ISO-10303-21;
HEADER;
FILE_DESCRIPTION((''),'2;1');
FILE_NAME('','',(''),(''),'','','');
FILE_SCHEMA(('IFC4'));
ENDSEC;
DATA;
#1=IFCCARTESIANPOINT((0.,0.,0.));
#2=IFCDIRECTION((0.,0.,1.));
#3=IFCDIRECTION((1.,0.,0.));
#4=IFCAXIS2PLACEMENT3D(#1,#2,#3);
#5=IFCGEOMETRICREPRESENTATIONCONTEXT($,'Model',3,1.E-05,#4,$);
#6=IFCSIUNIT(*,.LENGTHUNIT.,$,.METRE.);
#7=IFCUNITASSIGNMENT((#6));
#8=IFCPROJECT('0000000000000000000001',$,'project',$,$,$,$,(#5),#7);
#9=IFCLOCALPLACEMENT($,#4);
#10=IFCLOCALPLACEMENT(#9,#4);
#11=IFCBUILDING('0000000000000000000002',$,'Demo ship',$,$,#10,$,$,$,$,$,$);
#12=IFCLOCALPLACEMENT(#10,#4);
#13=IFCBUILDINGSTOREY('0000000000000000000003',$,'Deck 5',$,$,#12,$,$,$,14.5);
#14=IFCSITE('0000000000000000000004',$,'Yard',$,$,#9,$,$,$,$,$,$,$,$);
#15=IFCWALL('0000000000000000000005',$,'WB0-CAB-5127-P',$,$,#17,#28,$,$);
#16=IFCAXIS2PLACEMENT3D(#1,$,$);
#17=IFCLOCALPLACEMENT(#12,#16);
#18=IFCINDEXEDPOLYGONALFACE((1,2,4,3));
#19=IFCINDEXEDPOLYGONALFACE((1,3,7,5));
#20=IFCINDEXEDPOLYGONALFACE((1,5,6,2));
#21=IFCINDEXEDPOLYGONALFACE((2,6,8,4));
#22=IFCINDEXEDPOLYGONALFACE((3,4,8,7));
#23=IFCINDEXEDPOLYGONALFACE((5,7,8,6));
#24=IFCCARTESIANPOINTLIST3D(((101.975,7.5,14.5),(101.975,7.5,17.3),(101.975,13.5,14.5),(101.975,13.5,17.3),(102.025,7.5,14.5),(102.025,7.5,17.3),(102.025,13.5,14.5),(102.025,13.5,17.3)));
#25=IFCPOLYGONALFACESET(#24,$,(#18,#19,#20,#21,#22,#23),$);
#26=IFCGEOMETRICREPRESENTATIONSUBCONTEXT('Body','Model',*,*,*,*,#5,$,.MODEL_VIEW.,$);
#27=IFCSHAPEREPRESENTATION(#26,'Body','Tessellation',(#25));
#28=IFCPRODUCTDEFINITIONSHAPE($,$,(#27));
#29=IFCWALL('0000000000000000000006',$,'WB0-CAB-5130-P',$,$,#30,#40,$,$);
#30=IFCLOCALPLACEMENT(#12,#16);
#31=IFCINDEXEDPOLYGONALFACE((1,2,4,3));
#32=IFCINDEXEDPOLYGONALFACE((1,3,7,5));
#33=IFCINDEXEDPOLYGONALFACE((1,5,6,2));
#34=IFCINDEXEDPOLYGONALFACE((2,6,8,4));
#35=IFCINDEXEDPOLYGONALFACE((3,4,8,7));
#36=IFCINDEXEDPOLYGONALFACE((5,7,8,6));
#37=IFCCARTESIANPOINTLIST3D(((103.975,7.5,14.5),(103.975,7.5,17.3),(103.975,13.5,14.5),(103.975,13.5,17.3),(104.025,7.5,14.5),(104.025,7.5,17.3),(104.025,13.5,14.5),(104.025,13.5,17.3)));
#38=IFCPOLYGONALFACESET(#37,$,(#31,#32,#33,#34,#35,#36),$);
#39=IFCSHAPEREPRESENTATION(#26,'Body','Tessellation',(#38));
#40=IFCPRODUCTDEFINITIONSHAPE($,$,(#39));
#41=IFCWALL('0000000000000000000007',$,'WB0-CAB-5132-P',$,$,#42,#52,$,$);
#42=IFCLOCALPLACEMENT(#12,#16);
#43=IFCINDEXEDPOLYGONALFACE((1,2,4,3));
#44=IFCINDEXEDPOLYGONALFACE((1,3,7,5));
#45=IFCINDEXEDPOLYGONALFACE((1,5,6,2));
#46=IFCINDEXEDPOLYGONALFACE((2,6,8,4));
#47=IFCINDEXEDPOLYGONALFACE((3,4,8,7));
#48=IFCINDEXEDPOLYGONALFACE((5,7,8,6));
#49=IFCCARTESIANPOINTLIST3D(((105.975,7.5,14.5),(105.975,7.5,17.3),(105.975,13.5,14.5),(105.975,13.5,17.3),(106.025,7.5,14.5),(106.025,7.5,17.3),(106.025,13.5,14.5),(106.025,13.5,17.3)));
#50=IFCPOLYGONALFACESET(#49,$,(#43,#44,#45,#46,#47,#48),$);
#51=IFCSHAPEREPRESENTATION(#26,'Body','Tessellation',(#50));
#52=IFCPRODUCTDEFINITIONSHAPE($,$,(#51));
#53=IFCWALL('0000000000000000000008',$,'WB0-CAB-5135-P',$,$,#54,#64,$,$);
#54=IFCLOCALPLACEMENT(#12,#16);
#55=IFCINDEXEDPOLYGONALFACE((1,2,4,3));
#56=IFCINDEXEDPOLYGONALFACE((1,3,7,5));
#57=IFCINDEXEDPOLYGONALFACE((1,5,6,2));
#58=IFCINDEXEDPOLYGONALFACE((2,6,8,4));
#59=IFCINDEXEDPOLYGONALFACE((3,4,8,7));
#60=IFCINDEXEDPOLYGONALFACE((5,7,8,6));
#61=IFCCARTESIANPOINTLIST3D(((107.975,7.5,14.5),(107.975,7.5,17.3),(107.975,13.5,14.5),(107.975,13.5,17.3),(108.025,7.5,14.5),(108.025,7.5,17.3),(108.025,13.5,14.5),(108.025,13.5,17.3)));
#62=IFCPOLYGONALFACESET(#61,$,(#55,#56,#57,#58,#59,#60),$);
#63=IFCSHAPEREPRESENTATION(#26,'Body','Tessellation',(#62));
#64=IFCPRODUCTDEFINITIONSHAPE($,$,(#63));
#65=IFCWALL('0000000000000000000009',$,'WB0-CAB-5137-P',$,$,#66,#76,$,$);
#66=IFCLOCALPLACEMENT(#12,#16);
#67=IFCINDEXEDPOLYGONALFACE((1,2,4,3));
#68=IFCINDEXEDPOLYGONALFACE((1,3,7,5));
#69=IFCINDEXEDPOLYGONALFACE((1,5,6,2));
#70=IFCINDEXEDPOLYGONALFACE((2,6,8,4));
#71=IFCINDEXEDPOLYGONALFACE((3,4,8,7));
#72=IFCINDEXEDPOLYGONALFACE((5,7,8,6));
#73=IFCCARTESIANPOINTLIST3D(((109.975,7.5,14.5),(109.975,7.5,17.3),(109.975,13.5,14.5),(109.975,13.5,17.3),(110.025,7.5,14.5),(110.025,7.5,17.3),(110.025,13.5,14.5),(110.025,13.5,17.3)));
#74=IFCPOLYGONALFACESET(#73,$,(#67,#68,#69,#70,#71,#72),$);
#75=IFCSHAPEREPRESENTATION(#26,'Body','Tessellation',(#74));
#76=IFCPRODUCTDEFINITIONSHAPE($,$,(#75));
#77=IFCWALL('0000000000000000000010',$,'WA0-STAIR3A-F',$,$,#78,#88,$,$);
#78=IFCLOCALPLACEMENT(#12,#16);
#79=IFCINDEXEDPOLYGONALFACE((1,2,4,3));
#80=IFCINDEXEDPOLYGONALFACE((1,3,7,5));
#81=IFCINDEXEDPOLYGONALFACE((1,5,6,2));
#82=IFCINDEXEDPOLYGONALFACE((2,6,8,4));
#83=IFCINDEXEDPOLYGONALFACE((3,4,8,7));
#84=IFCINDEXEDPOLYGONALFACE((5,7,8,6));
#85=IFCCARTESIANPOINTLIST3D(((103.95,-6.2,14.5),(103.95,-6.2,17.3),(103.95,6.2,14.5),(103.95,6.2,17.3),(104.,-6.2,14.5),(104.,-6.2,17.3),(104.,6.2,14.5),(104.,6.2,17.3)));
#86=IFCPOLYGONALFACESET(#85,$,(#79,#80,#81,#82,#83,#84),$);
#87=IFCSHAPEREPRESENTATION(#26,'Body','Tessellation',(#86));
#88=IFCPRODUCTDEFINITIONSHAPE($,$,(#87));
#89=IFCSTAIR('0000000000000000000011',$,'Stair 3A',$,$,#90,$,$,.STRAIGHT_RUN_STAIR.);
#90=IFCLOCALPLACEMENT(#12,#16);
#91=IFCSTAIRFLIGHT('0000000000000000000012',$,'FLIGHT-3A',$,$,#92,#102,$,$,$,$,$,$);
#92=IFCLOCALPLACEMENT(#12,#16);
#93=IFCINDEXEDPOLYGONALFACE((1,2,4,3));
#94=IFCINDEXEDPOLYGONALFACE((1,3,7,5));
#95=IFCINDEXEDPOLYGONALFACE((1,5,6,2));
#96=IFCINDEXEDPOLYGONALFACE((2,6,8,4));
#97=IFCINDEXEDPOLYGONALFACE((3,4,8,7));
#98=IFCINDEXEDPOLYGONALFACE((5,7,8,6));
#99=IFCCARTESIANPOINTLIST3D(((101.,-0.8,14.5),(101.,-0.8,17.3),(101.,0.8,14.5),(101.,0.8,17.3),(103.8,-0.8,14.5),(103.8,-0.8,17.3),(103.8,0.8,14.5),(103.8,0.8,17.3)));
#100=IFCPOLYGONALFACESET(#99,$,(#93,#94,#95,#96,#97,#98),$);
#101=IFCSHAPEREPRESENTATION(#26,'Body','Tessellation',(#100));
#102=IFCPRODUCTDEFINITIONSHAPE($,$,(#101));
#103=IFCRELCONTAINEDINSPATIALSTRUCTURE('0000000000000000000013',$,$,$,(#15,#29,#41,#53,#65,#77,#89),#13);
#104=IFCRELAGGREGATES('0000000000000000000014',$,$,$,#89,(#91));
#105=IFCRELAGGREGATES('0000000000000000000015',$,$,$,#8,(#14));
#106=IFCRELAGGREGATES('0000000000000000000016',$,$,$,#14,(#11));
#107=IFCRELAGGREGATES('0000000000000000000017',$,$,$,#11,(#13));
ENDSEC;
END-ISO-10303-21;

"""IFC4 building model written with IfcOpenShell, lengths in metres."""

from ifc_helpers import new_model, si_unit, frame, frame_2d, origin, origin_with_axes, place, context, subcontext, project, spatial, rectangle, extrude, element, aggregate, save


model = new_model("IFC4")

# Units and contexts
model_context = context("Model", 3, precision=1e-05, world=origin_with_axes())
body_context = subcontext(model_context, "Body", "Model", "MODEL_VIEW")
ifc_project = project(units=[si_unit("LENGTHUNIT", "METRE")], contexts=[model_context])

# Site, building, storey
site_placement = place(None, origin_with_axes())
site = spatial("IfcSite", under=ifc_project, at=site_placement, Name="Yard")
building_placement = place(site_placement, origin_with_axes())
building = spatial("IfcBuilding", under=site, at=building_placement, Name="Demo ship")
storey_placement = place(building_placement, origin_with_axes())
storey = spatial("IfcBuildingStorey", under=building, at=storey_placement, Name="Deck 5", Elevation=14.5)

# Walls
for number, where, z_axis, x_axis, name in (
    (1, (101.975, 7.5, 14.5), (0.0, 0.0, 1.0), (1.0, 0.0, 0.0), "WB0-CAB-5127-P"),
    (2, (103.975, 7.5, 14.5), (0.0, 0.0, 1.0), (1.0, 0.0, 0.0), "WB0-CAB-5130-P"),
    (3, (105.975, 7.5, 14.5), (0.0, 0.0, 1.0), (1.0, 0.0, 0.0), "WB0-CAB-5132-P"),
    (4, (107.975, 7.5, 14.5), (0.0, 0.0, 1.0), (1.0, 0.0, 0.0), "WB0-CAB-5135-P"),
    (5, (109.975, 7.5, 14.5), (0.0, 0.0, 1.0), (1.0, 0.0, 0.0), "WB0-CAB-5137-P"),
):
    element("IfcWall", number, at=place(storey_placement, frame(where, z_axis=z_axis, x_axis=x_axis)), inside=storey, Name=name, context=body_context, shape_type="SweptSolid", body=[
        extrude(rectangle(XDim=0.05, YDim=6.0, at=frame_2d((0.025, 3.0))), origin(), (0.0, 0.0, 1.0), 2.8),
    ])
wall_placement = place(storey_placement, frame((103.95, -6.2, 14.5), z_axis=(0.0, 0.0, 1.0), x_axis=(1.0, 0.0, 0.0)))
element("IfcWall", 6, at=wall_placement, inside=storey, Name="WA0-STAIR3A-F", context=body_context, shape_type="SweptSolid", body=[
    extrude(rectangle(XDim=0.05, YDim=12.4, at=frame_2d((0.025, 6.2))), origin(), (0.0, 0.0, 1.0), 2.8),
])

# Stair, stair flight
stair_placement = place(storey_placement, frame((101.0, -0.8, 14.5), z_axis=(0.0, 0.0, 1.0), x_axis=(1.0, 0.0, 0.0)))
stair = element("IfcStair", 7, at=stair_placement, inside=storey, Name="Stair 3A", PredefinedType="STRAIGHT_RUN_STAIR")
stair_flight_placement = place(stair_placement, origin_with_axes())
stair_flight = element("IfcStairFlight", 8, at=stair_flight_placement, Name="FLIGHT-3A", context=body_context, shape_type="SweptSolid", body=[
    extrude(rectangle(XDim=2.8, YDim=1.6, at=frame_2d((1.4, 0.8))), origin(), (0.0, 0.0, 1.0), 2.8),
])
aggregate(stair, [stair_flight])

save(model, "model.ifc")
